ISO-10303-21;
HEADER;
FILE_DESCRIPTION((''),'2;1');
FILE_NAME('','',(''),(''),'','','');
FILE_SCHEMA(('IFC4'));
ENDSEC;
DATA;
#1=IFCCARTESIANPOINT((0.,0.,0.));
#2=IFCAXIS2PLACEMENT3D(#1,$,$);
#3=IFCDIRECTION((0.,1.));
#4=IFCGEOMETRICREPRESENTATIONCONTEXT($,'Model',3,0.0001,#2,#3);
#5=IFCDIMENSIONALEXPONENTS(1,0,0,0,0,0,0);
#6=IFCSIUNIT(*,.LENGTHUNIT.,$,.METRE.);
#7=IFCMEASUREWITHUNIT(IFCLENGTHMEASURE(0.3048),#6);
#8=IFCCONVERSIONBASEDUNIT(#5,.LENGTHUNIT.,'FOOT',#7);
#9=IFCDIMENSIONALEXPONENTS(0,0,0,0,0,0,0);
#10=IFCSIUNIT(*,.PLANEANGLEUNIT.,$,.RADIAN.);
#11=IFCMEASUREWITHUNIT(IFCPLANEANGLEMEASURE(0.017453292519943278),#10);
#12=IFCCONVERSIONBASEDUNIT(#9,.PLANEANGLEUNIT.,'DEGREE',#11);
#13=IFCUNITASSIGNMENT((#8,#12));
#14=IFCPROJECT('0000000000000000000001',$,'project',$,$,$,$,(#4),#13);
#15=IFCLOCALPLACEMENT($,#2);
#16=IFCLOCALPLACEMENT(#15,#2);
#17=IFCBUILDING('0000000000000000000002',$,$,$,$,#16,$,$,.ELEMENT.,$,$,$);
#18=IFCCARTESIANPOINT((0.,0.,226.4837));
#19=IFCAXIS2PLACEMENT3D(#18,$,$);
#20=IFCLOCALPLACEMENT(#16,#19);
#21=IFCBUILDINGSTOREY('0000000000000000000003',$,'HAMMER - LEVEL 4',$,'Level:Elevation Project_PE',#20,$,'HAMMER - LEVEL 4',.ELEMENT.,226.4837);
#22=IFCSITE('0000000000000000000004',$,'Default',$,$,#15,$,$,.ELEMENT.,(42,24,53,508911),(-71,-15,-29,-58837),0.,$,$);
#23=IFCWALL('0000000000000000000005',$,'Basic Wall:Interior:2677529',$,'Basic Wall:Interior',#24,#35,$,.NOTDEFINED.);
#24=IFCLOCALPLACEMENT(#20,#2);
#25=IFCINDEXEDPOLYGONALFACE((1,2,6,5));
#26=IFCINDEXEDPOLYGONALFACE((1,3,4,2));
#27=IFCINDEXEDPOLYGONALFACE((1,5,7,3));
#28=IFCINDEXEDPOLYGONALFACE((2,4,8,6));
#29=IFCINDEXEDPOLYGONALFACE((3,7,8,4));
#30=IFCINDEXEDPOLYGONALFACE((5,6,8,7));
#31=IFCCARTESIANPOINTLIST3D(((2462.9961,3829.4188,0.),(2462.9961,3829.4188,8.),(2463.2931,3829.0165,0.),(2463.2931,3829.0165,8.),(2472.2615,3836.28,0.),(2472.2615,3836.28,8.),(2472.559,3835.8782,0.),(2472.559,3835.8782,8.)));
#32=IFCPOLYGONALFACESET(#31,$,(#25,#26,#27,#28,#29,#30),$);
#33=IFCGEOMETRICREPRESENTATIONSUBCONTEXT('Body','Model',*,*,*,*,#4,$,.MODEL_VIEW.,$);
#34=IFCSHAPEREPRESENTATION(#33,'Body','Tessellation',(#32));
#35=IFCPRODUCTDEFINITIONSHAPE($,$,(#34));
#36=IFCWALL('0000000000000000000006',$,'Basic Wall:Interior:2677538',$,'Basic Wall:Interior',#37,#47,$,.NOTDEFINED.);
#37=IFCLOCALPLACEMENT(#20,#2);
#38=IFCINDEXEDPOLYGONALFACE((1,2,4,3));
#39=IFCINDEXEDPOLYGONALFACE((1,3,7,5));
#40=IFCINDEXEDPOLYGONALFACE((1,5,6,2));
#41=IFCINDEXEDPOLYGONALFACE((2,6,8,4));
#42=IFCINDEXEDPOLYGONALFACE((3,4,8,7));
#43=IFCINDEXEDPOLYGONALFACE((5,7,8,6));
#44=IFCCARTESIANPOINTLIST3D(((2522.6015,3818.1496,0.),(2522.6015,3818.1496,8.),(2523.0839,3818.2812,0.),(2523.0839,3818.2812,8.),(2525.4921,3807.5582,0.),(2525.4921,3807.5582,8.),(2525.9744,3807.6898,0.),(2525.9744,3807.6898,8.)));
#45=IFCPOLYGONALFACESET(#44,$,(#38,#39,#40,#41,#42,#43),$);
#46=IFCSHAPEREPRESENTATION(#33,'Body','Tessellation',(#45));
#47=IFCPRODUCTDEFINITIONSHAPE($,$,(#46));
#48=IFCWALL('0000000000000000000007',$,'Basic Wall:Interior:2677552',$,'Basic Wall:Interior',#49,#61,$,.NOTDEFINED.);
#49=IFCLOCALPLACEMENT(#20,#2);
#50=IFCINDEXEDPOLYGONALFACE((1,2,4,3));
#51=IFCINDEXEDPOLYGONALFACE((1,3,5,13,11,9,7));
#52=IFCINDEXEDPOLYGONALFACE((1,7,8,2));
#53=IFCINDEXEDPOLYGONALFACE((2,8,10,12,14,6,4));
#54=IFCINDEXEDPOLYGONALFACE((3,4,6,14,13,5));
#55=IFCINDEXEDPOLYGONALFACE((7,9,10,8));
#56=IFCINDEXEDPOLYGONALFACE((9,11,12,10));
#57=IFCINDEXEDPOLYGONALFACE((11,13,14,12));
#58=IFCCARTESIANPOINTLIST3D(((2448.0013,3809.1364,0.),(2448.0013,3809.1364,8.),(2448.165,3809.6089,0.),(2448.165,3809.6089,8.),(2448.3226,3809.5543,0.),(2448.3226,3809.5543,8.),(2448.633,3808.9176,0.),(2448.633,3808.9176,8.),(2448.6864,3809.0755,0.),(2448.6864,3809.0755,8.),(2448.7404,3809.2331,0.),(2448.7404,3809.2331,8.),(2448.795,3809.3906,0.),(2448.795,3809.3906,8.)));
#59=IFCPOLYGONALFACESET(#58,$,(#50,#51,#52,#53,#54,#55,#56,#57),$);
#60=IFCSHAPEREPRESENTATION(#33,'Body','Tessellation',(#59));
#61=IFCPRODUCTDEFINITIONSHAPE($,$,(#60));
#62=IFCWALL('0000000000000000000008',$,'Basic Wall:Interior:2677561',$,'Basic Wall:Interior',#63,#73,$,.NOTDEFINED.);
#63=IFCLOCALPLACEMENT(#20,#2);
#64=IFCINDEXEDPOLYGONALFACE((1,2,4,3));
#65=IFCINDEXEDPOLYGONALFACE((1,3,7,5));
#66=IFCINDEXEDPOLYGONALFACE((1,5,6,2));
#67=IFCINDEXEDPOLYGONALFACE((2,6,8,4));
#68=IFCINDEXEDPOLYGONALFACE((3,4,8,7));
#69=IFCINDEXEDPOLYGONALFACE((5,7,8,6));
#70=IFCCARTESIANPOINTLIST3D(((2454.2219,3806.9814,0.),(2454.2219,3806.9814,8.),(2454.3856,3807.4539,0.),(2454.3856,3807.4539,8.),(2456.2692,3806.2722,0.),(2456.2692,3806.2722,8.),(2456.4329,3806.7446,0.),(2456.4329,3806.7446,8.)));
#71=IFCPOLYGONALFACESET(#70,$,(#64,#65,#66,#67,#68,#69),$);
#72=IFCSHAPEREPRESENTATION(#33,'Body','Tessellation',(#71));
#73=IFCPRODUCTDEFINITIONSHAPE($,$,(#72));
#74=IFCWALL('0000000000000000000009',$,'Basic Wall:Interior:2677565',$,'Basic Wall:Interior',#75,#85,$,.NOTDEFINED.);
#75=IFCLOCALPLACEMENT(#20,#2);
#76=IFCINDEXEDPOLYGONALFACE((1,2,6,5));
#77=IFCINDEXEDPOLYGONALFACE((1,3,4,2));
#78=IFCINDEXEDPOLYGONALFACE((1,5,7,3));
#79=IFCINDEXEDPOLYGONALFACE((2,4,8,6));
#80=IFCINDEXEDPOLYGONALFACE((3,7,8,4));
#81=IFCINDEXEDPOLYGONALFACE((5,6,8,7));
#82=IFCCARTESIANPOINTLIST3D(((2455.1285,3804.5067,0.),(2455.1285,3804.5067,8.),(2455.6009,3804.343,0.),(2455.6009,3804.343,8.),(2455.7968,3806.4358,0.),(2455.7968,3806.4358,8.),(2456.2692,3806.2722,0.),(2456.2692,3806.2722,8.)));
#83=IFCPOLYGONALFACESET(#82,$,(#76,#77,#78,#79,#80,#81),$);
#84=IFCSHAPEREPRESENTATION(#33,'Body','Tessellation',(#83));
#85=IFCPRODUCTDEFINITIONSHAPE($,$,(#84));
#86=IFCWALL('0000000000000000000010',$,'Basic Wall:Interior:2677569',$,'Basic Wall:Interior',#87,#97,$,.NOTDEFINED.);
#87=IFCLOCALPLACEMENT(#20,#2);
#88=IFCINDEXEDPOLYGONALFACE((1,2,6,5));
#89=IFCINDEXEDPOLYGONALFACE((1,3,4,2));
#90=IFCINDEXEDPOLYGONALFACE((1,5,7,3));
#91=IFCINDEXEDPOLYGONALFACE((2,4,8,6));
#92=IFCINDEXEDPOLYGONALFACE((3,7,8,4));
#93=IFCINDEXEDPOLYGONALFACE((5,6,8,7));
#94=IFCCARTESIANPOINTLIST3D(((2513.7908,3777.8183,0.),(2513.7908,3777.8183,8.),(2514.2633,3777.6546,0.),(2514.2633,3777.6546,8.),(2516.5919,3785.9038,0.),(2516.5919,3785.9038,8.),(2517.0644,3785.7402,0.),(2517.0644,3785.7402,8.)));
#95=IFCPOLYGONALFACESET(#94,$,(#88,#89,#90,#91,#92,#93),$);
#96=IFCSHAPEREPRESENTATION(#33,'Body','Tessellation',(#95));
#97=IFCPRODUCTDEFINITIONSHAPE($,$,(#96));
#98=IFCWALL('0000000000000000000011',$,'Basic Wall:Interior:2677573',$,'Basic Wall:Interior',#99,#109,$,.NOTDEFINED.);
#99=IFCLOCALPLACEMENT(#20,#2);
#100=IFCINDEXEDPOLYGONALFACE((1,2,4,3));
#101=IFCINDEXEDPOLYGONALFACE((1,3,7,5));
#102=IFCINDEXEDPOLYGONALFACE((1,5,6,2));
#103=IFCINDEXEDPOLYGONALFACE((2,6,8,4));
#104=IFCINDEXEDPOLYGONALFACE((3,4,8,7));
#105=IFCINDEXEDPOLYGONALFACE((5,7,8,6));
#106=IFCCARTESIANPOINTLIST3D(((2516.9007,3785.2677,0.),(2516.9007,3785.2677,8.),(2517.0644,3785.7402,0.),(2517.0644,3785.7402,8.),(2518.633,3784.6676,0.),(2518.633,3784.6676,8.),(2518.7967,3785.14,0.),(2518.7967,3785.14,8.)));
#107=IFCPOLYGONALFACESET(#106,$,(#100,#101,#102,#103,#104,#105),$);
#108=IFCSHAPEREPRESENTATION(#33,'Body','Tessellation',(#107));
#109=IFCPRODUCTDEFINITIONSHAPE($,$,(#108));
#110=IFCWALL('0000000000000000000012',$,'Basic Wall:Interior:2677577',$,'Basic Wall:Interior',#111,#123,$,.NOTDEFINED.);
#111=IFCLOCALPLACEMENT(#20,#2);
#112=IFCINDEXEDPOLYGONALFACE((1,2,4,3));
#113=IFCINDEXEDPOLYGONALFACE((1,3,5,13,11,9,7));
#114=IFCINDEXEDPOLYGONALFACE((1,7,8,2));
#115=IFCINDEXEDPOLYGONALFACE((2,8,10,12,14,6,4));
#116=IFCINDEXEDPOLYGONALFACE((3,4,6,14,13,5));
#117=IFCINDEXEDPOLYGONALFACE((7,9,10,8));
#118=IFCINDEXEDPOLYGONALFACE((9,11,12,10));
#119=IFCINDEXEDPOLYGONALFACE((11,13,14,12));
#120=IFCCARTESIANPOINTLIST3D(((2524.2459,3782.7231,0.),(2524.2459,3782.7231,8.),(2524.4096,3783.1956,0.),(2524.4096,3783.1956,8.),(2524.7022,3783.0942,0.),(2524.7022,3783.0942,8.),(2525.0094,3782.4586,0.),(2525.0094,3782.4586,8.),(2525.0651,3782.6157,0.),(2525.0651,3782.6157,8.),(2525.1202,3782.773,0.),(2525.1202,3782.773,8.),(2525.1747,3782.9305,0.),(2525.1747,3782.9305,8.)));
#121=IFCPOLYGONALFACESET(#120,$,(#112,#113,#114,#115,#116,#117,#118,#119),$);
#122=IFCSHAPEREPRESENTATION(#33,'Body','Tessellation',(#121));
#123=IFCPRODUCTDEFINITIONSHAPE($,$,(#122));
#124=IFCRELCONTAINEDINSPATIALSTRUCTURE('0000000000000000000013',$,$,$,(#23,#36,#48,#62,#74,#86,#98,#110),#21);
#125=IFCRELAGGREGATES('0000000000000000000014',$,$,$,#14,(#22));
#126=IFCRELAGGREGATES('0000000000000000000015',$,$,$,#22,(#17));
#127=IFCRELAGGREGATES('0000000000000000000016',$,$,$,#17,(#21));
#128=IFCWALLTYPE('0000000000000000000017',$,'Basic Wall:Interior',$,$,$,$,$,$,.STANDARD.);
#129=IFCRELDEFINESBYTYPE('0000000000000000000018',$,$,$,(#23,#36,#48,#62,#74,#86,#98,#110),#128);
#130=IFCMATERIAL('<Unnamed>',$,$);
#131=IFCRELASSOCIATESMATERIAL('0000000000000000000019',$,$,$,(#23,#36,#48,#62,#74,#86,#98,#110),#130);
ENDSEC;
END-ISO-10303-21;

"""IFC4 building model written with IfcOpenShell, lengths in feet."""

from ifc_helpers import new_model, entity, si_unit, converted_unit, direction, frame, origin, place, context, subcontext, project, spatial, line, arc, indexed_curve, outline, extrude, material, type_object, element, save


model = new_model("IFC4")

# Units and contexts
model_context = context("Model", 3, precision=0.0001, world=origin(), true_north=direction((0.0, 1.0)))
body_context = subcontext(model_context, "Body", "Model", "MODEL_VIEW")
ifc_project = project(units=[converted_unit("LENGTHUNIT", "FOOT", entity("IfcLengthMeasure", 0.3048), si_unit("LENGTHUNIT", "METRE"), dimensions=[1, 0, 0, 0, 0, 0, 0]), converted_unit("PLANEANGLEUNIT", "DEGREE", entity("IfcPlaneAngleMeasure", 0.017453292519943278), si_unit("PLANEANGLEUNIT", "RADIAN"), dimensions=[0, 0, 0, 0, 0, 0, 0])], contexts=[model_context])

# Site, building, storey
site_placement = place(None, origin())
site = spatial("IfcSite", under=ifc_project, at=site_placement, Name="Default", CompositionType="ELEMENT", RefLatitude=(42, 24, 53, 508911), RefLongitude=(-71, -15, -29, -58837), RefElevation=0.0)
building_placement = place(site_placement, origin())
building = spatial("IfcBuilding", under=site, at=building_placement, CompositionType="ELEMENT")
storey_placement = place(building_placement, frame((0.0, 0.0, 226.4837)))
storey = spatial("IfcBuildingStorey", under=building, at=storey_placement, Name="HAMMER - LEVEL 4", ObjectType="Level:Elevation Project_PE", LongName="HAMMER - LEVEL 4", CompositionType="ELEMENT", Elevation=226.4837)

# Walls
ifc_material = material(Name="<Unnamed>")
wall_type = type_object("IfcWallType", Name="Basic Wall:Interior", PredefinedType="STANDARD")
wall_1_placement = place(storey_placement, frame((2463.1443, 3829.2174, 0.0), z_axis=(0.0, 0.0, 1.0), x_axis=(0.803642, 0.595113, 0.0)))
element("IfcWall", 1, at=wall_1_placement, inside=storey, type_object=wall_type, material=ifc_material, Name="Basic Wall:Interior:2677529", ObjectType="Basic Wall:Interior", PredefinedType="NOTDEFINED", context=body_context, shape_type="SweptSolid", body=[
    extrude(outline(indexed_curve([(11.53, -0.25), (11.53, 0.25), (0.0008, 0.25), (0.0, -0.25), (11.53, -0.25)], self_intersect=False)), origin(), (0.0, 0.0, 1.0), 8.0),
])
wall_2_placement = place(storey_placement, frame((2522.8427, 3818.2154, 0.0), z_axis=(0.0, 0.0, 1.0), x_axis=(0.263287, -0.964718, 0.0)))
element("IfcWall", 2, at=wall_2_placement, inside=storey, type_object=wall_type, material=ifc_material, Name="Basic Wall:Interior:2677538", ObjectType="Basic Wall:Interior", PredefinedType="NOTDEFINED", context=body_context, shape_type="SweptSolid", body=[
    extrude(outline(indexed_curve([(10.9788, 0.25), (0.0, 0.25), (0.0, -0.25), (10.9788, -0.25), (10.9788, 0.25)], self_intersect=False)), origin(), (0.0, 0.0, 1.0), 8.0),
])
wall_3_placement = place(storey_placement, frame((2448.7149, 3809.1538, 0.0), z_axis=(0.0, 0.0, 1.0), x_axis=(-0.944906, 0.327342, 0.0)))
element("IfcWall", 3, at=wall_3_placement, inside=storey, type_object=wall_type, material=ifc_material, Name="Basic Wall:Interior:2677552", ObjectType="Basic Wall:Interior", PredefinedType="NOTDEFINED", context=body_context, shape_type="SweptSolid", body=[
    extrude(outline(indexed_curve([(0.6686, -0.25), (0.6686, 0.25), (0.0, 0.25), (0.0016, 0.0), (0.0018, -0.25), (0.5018, -0.25)], segments=[line(1, 2, 3), arc(3, 4, 5), line(5, 6, 1)], self_intersect=False)), origin(), (0.0, 0.0, 1.0), 8.0),
])
wall_4_placement = place(storey_placement, frame((2456.3511, 3806.5084, 0.0), z_axis=(0.0, 0.0, 1.0), x_axis=(-0.944906, 0.327342, 0.0)))
element("IfcWall", 4, at=wall_4_placement, inside=storey, type_object=wall_type, material=ifc_material, Name="Basic Wall:Interior:2677561", ObjectType="Basic Wall:Interior", PredefinedType="NOTDEFINED", context=body_context, shape_type="SweptSolid", body=[
    extrude(outline(indexed_curve([(2.1667, 0.25), (0.0, 0.25), (0.0, -0.25), (2.1667, -0.25), (2.1667, 0.25)], self_intersect=False)), origin(), (0.0, 0.0, 1.0), 8.0),
])
wall_5_placement = place(storey_placement, frame((2455.3647, 3804.4248, 0.0), z_axis=(0.0, 0.0, 1.0), x_axis=(0.327342, 0.944906, 0.0)))
element("IfcWall", 5, at=wall_5_placement, inside=storey, type_object=wall_type, material=ifc_material, Name="Basic Wall:Interior:2677565", ObjectType="Basic Wall:Interior", PredefinedType="NOTDEFINED", context=body_context, shape_type="SweptSolid", body=[
    extrude(outline(indexed_curve([(2.0417, 0.25), (0.0, 0.25), (0.0, -0.25), (2.0417, -0.25), (2.0417, 0.25)], self_intersect=False)), origin(), (0.0, 0.0, 1.0), 8.0),
])
wall_6_placement = place(storey_placement, frame((2516.8281, 3785.822, 0.0), z_axis=(0.0, 0.0, 1.0), x_axis=(-0.327342, -0.944906, 0.0)))
element("IfcWall", 6, at=wall_6_placement, inside=storey, type_object=wall_type, material=ifc_material, Name="Basic Wall:Interior:2677569", ObjectType="Basic Wall:Interior", PredefinedType="NOTDEFINED", context=body_context, shape_type="SweptSolid", body=[
    extrude(outline(indexed_curve([(8.557, 0.25), (0.0, 0.25), (0.0, -0.25), (8.557, -0.25), (8.557, 0.25)], self_intersect=False)), origin(), (0.0, 0.0, 1.0), 8.0),
])
wall_7_placement = place(storey_placement, frame((2518.7149, 3784.9038, 0.0), z_axis=(0.0, 0.0, 1.0), x_axis=(-0.944906, 0.327342, 0.0)))
element("IfcWall", 7, at=wall_7_placement, inside=storey, type_object=wall_type, material=ifc_material, Name="Basic Wall:Interior:2677573", ObjectType="Basic Wall:Interior", PredefinedType="NOTDEFINED", context=body_context, shape_type="SweptSolid", body=[
    extrude(outline(indexed_curve([(1.8333, 0.25), (0.0, 0.25), (0.0, -0.25), (1.8333, -0.25), (1.8333, 0.25)], self_intersect=False)), origin(), (0.0, 0.0, 1.0), 8.0),
])
wall_8_placement = place(storey_placement, frame((2525.0928, 3782.6943, 0.0), z_axis=(0.0, 0.0, 1.0), x_axis=(-0.944906, 0.327342, 0.0)))
element("IfcWall", 8, at=wall_8_placement, inside=storey, type_object=wall_type, material=ifc_material, Name="Basic Wall:Interior:2677577", ObjectType="Basic Wall:Interior", PredefinedType="NOTDEFINED", context=body_context, shape_type="SweptSolid", body=[
    extrude(outline(indexed_curve([(0.8097, -0.25), (0.8097, 0.25), (0.0017, 0.25), (0.0001, 0.0), (0.0, -0.25), (0.5, -0.25)], segments=[line(1, 2, 3), arc(3, 4, 5), line(5, 6, 1)], self_intersect=False)), origin(), (0.0, 0.0, 1.0), 8.0),
])

save(model, "model.ifc")
